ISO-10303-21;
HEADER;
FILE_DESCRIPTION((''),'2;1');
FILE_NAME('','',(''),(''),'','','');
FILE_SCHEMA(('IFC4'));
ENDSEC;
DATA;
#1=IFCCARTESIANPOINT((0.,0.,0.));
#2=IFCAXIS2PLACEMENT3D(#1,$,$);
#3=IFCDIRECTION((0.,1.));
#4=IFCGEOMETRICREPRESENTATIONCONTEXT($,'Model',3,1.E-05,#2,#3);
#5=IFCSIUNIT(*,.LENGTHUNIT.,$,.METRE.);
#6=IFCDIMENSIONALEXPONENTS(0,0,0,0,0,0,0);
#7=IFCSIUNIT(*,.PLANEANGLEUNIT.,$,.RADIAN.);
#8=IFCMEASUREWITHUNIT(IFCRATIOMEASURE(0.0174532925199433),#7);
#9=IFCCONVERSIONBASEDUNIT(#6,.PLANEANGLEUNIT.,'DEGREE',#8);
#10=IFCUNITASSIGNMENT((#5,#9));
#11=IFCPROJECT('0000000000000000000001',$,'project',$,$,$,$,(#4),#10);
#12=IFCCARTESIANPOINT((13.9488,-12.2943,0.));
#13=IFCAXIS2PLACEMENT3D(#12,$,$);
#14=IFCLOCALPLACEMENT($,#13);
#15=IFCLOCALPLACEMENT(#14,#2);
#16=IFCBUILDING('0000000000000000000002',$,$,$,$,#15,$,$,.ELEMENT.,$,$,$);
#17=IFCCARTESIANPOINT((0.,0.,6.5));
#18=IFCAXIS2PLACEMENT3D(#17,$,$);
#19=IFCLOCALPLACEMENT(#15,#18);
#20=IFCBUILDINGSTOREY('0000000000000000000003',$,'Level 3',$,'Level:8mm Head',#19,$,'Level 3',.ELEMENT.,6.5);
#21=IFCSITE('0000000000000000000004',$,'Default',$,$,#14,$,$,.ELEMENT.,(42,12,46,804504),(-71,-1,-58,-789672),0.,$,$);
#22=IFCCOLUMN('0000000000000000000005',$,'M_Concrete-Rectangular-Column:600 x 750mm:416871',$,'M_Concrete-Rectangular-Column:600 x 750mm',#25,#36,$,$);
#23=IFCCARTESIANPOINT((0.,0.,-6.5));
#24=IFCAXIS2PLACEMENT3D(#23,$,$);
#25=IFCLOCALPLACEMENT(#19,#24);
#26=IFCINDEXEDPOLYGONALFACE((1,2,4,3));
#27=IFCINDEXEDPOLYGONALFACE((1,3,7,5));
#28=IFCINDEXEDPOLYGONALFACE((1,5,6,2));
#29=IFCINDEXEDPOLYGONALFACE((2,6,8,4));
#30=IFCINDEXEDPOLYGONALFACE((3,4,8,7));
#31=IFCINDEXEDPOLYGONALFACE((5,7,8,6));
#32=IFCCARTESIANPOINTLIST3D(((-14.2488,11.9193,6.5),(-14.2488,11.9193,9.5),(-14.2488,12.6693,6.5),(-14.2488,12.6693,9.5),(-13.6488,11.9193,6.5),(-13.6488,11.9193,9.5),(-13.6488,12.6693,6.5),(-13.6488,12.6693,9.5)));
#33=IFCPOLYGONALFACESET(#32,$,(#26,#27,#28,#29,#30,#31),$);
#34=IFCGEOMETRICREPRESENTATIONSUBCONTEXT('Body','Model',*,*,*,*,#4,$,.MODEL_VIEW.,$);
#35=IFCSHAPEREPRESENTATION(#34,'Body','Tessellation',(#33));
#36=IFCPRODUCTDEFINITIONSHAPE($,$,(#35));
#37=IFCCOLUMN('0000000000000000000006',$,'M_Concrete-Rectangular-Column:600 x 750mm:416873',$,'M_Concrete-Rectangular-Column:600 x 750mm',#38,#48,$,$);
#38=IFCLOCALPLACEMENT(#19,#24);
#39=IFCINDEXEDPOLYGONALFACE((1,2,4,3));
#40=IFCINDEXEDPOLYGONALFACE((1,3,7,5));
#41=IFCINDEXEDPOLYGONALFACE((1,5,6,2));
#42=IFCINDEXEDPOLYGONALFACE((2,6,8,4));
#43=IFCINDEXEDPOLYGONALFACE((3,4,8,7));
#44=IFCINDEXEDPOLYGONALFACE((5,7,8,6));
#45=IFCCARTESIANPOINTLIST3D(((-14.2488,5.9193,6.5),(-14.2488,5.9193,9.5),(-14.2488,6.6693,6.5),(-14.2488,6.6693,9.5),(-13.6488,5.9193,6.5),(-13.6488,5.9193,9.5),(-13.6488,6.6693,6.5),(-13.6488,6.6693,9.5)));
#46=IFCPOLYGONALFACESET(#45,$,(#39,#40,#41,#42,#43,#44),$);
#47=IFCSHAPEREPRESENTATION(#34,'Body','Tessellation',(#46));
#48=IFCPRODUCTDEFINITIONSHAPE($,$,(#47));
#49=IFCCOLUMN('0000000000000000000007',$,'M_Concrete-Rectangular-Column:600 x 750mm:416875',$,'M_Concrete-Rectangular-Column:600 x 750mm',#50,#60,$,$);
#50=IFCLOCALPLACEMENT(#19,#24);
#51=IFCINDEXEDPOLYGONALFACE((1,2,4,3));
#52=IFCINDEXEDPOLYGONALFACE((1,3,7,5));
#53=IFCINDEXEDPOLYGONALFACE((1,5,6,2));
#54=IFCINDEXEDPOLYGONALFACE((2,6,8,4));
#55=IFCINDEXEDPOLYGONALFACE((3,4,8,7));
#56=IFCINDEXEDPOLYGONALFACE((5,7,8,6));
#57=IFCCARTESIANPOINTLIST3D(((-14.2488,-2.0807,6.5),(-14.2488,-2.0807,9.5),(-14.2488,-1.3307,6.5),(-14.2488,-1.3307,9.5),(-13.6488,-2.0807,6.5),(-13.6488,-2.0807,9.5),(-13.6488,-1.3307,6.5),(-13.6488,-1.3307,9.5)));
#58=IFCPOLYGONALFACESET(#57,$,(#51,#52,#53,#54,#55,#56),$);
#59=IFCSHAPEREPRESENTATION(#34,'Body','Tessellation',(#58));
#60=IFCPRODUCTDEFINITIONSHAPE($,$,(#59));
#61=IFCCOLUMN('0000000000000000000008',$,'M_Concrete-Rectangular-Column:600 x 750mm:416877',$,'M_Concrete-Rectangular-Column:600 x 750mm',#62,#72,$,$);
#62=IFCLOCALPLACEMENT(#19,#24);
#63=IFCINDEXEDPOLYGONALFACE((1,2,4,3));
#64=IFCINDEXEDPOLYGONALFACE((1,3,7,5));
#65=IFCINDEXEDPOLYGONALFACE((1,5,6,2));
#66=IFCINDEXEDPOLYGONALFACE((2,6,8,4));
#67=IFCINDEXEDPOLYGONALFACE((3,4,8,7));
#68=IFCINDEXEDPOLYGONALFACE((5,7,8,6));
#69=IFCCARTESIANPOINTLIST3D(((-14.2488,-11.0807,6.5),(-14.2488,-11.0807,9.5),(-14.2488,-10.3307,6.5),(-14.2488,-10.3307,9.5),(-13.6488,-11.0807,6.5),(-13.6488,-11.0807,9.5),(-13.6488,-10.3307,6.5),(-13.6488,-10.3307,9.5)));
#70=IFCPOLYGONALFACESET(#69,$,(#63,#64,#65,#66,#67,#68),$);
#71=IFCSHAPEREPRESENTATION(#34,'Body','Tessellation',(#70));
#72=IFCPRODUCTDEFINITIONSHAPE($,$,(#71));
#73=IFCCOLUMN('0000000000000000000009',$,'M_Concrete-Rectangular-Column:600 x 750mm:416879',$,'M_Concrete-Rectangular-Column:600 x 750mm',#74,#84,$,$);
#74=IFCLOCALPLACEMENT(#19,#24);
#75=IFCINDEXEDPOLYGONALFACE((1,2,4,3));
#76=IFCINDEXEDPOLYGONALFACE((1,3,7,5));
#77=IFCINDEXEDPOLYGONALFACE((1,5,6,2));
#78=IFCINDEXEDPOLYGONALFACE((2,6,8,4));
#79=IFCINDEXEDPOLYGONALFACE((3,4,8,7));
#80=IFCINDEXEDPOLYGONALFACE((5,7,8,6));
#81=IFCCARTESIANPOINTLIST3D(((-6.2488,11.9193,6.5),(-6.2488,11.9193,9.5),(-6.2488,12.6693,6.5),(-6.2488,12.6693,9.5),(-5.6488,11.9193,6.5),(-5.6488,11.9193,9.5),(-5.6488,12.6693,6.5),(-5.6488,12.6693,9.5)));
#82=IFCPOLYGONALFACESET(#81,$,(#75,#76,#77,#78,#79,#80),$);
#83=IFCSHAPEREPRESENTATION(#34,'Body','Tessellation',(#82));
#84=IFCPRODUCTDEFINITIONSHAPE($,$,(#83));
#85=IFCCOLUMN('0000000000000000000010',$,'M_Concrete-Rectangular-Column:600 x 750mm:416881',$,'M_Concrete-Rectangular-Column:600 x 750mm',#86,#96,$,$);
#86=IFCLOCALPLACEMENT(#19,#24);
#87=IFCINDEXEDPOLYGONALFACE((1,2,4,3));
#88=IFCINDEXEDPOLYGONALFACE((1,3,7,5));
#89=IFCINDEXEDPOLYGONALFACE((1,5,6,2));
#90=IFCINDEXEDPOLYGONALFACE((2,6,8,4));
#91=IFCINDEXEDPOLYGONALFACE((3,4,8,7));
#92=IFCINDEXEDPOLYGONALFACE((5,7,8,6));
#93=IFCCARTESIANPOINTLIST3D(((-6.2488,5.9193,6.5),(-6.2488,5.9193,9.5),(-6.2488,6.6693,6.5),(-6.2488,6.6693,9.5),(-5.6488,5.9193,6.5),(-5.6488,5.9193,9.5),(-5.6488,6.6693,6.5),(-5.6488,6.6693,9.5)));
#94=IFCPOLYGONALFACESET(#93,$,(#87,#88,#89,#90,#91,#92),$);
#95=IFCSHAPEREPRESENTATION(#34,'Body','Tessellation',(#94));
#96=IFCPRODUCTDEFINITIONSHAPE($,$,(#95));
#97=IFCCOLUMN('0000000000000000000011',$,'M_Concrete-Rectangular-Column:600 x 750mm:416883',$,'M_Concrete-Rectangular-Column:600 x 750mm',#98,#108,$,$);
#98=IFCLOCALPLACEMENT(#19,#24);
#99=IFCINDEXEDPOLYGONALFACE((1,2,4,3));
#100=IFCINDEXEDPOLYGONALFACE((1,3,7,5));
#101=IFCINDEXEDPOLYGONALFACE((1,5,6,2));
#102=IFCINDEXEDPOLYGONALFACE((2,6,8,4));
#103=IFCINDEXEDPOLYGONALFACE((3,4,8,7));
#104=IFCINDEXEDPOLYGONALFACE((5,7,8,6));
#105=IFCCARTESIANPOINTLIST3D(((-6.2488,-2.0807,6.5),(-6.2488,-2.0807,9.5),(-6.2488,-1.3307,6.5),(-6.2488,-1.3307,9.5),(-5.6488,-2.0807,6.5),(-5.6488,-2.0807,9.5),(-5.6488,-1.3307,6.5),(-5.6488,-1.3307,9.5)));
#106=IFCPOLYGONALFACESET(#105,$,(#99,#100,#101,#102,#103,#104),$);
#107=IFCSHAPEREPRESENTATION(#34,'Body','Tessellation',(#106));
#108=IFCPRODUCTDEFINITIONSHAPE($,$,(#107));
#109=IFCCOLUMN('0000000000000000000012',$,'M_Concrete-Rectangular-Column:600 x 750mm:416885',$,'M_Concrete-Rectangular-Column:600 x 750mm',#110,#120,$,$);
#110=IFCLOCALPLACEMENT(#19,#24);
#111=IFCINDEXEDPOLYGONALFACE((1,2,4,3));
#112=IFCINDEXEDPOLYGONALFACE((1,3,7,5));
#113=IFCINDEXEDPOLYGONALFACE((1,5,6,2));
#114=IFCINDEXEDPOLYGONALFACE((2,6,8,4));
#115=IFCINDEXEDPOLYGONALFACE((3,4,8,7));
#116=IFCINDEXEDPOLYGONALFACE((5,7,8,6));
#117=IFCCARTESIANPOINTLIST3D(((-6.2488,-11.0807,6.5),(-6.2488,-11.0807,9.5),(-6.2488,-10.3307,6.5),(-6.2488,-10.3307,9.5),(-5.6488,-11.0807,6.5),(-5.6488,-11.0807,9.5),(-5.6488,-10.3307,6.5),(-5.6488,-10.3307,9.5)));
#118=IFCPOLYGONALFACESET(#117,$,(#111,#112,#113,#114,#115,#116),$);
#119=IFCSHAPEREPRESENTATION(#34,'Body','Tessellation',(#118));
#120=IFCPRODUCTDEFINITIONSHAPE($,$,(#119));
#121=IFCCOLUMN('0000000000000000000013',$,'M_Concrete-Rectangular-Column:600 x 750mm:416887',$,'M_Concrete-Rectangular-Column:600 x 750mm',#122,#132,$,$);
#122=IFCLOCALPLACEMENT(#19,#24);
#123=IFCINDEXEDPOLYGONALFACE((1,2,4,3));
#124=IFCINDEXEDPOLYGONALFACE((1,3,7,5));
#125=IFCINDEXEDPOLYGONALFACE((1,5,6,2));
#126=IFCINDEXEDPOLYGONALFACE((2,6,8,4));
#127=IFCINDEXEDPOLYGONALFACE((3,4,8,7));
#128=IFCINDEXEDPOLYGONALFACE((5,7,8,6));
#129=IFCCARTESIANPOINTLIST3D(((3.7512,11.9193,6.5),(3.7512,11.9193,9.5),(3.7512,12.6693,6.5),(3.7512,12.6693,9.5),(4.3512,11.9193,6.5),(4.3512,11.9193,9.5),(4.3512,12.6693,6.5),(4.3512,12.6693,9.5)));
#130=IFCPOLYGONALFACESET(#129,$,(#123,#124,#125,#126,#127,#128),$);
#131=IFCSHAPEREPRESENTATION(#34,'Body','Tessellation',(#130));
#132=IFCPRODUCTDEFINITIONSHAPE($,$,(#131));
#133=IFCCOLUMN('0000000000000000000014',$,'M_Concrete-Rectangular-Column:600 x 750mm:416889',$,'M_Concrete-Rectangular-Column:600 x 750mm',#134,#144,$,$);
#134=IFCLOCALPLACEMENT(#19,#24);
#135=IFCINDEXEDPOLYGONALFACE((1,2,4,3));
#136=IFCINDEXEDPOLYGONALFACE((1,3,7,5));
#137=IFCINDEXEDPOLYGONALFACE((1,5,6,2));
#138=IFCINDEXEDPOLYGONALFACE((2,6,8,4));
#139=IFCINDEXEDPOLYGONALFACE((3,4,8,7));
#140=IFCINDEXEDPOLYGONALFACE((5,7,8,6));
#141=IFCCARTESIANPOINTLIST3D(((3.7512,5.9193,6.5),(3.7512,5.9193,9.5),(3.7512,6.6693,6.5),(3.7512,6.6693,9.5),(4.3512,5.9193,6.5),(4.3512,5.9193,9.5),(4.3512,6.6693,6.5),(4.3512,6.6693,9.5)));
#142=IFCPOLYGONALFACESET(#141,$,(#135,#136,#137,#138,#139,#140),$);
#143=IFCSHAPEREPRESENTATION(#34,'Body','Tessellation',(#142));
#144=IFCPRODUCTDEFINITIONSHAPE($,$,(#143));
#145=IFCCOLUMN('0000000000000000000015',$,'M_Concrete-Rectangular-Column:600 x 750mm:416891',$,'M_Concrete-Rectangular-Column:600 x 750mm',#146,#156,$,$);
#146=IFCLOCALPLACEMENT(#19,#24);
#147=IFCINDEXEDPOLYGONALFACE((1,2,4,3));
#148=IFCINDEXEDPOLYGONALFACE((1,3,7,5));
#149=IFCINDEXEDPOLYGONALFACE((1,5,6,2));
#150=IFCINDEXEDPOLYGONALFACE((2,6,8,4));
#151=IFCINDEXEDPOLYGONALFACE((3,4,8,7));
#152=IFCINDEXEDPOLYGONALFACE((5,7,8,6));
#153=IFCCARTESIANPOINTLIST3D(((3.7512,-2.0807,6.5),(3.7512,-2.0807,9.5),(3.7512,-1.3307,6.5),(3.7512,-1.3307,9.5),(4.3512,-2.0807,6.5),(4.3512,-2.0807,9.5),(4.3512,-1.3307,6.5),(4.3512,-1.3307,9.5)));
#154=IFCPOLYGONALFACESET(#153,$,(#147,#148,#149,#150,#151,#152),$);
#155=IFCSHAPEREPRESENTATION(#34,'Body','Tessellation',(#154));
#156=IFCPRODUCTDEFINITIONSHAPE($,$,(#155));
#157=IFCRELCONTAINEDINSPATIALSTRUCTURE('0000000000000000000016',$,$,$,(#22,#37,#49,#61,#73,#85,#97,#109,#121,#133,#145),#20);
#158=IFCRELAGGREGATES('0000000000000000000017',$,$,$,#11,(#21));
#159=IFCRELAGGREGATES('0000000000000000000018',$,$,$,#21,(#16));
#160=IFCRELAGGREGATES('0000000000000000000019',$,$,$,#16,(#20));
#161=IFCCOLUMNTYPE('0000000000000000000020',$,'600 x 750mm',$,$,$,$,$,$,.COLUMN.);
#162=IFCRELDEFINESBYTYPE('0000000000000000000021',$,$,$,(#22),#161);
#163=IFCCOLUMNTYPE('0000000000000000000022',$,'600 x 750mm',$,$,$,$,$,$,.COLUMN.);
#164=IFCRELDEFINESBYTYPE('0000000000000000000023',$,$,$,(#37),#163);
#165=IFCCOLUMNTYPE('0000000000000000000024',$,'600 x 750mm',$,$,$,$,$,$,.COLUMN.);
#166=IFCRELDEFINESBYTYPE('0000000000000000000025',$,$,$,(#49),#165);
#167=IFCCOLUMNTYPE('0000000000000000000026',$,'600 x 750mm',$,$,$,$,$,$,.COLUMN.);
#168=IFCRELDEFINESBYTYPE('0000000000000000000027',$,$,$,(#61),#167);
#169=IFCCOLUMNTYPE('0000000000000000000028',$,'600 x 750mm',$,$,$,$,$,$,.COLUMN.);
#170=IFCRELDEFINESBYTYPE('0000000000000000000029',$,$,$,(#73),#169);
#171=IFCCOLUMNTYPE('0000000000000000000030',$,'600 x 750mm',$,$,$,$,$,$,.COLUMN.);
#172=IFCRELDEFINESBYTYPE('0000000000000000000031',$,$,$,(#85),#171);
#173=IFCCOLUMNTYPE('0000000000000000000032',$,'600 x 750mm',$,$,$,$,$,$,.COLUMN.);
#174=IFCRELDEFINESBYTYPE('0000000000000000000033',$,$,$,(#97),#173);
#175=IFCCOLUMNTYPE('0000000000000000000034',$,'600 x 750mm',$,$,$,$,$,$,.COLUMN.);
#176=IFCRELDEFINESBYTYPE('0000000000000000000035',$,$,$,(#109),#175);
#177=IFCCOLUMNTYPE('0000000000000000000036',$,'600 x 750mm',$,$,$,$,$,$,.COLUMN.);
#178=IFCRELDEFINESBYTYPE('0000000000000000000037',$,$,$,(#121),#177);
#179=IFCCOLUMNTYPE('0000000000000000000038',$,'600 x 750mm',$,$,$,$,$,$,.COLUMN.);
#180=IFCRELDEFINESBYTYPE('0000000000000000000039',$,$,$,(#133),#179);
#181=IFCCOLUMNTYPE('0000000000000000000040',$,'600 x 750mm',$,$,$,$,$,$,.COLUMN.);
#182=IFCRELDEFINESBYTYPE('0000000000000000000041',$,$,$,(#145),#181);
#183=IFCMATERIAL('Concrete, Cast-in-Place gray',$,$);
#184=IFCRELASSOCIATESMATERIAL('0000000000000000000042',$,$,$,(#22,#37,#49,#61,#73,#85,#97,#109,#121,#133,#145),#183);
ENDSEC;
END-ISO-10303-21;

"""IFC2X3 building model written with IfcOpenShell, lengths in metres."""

from ifc_helpers import new_model, entity, si_unit, converted_unit, direction, frame, frame_2d, origin, origin_2d_with_axis, place, context, subcontext, project, spatial, rectangle, extrude, source, transform, mapped, material, type_object, type_shapes, element, save


model = new_model("IFC2X3")

# Units and contexts
model_context = context("Model", 3, precision=1e-05, world=origin(), true_north=direction((0.0, 1.0)))
body_context = subcontext(model_context, "Body", "Model", "MODEL_VIEW")
ifc_project = project(units=[si_unit("LENGTHUNIT", "METRE"), converted_unit("PLANEANGLEUNIT", "DEGREE", entity("IfcRatioMeasure", 0.0174532925199433), si_unit("PLANEANGLEUNIT", "RADIAN"), dimensions=[0, 0, 0, 0, 0, 0, 0])], contexts=[model_context])

# Site, building, storey
site_placement = place(None, frame((13.9488, -12.2943, 0.0)))
site = spatial("IfcSite", under=ifc_project, at=site_placement, Name="Default", CompositionType="ELEMENT", RefLatitude=(42, 12, 46, 804504), RefLongitude=(-71, -1, -58, -789672), RefElevation=0.0)
building_placement = place(site_placement, origin())
building = spatial("IfcBuilding", under=site, at=building_placement, CompositionType="ELEMENT")
storey_placement = place(building_placement, frame((0.0, 0.0, 6.5)))
storey = spatial("IfcBuildingStorey", under=building, at=storey_placement, Name="Level 3", ObjectType="Level:8mm Head", LongName="Level 3", CompositionType="ELEMENT", Elevation=6.5)

# Columns
ifc_material = material(Name="Concrete, Cast-in-Place gray")
column_type_1 = type_object("IfcColumnType", Name="600 x 750mm", PredefinedType="COLUMN")
shared_shape_1 = source(origin(), body_context, "Body", "SweptSolid", [
    extrude(rectangle(XDim=0.75, YDim=0.6, at=frame_2d((0.0, 0.0), x_axis=(1.0, 0.0))), frame((-13.9488, 12.2943, 6.5), z_axis=(0.0, 0.0, 1.0), x_axis=(0.0, -1.0, 0.0)), (0.0, 0.0, 1.0), 3.0),
])
type_shapes(column_type_1, [shared_shape_1])
column_1_placement = place(storey_placement, frame((0.0, 0.0, -6.5)))
element("IfcColumn", 1, at=column_1_placement, inside=storey, type_object=column_type_1, material=ifc_material, Name="M_Concrete-Rectangular-Column:600 x 750mm:416871", ObjectType="M_Concrete-Rectangular-Column:600 x 750mm", context=body_context, shape_type="MappedRepresentation", body=[
    mapped(shared_shape_1, transform((0.0, 0.0, 0.0), scale=1.0)),
])
column_type_2 = type_object("IfcColumnType", Name="600 x 750mm", PredefinedType="COLUMN")
shared_shape_2 = source(origin(), body_context, "Body", "SweptSolid", [
    extrude(rectangle(XDim=0.75, YDim=0.6, at=frame_2d((0.0, 0.0), x_axis=(1.0, 0.0))), frame((-13.9488, 6.2943, 6.5), z_axis=(0.0, 0.0, 1.0), x_axis=(0.0, -1.0, 0.0)), (0.0, 0.0, 1.0), 3.0),
])
type_shapes(column_type_2, [shared_shape_2])
column_2_placement = place(storey_placement, frame((0.0, 0.0, -6.5)))
element("IfcColumn", 2, at=column_2_placement, inside=storey, type_object=column_type_2, material=ifc_material, Name="M_Concrete-Rectangular-Column:600 x 750mm:416873", ObjectType="M_Concrete-Rectangular-Column:600 x 750mm", context=body_context, shape_type="MappedRepresentation", body=[
    mapped(shared_shape_2, transform((0.0, 0.0, 0.0), scale=1.0)),
])
column_type_3 = type_object("IfcColumnType", Name="600 x 750mm", PredefinedType="COLUMN")
shared_shape_3 = source(origin(), body_context, "Body", "SweptSolid", [
    extrude(rectangle(XDim=0.75, YDim=0.6, at=frame_2d((0.0, 0.0), x_axis=(1.0, 0.0))), frame((-13.9488, -1.7057, 6.5), z_axis=(0.0, 0.0, 1.0), x_axis=(0.0, -1.0, 0.0)), (0.0, 0.0, 1.0), 3.0),
])
type_shapes(column_type_3, [shared_shape_3])
column_3_placement = place(storey_placement, frame((0.0, 0.0, -6.5)))
element("IfcColumn", 3, at=column_3_placement, inside=storey, type_object=column_type_3, material=ifc_material, Name="M_Concrete-Rectangular-Column:600 x 750mm:416875", ObjectType="M_Concrete-Rectangular-Column:600 x 750mm", context=body_context, shape_type="MappedRepresentation", body=[
    mapped(shared_shape_3, transform((0.0, 0.0, 0.0), scale=1.0)),
])
column_type_4 = type_object("IfcColumnType", Name="600 x 750mm", PredefinedType="COLUMN")
shared_shape_4 = source(origin(), body_context, "Body", "SweptSolid", [
    extrude(rectangle(XDim=0.75, YDim=0.6, at=frame_2d((0.0, 0.0), x_axis=(1.0, 0.0))), frame((-13.9488, -10.7057, 6.5), z_axis=(0.0, 0.0, 1.0), x_axis=(0.0, -1.0, 0.0)), (0.0, 0.0, 1.0), 3.0),
])
type_shapes(column_type_4, [shared_shape_4])
column_4_placement = place(storey_placement, frame((0.0, 0.0, -6.5)))
element("IfcColumn", 4, at=column_4_placement, inside=storey, type_object=column_type_4, material=ifc_material, Name="M_Concrete-Rectangular-Column:600 x 750mm:416877", ObjectType="M_Concrete-Rectangular-Column:600 x 750mm", context=body_context, shape_type="MappedRepresentation", body=[
    mapped(shared_shape_4, transform((0.0, 0.0, 0.0), scale=1.0)),
])
column_type_5 = type_object("IfcColumnType", Name="600 x 750mm", PredefinedType="COLUMN")
shared_shape_5 = source(origin(), body_context, "Body", "SweptSolid", [
    extrude(rectangle(XDim=0.75, YDim=0.6, at=origin_2d_with_axis()), frame((-5.9488, 12.2943, 6.5), z_axis=(0.0, 0.0, 1.0), x_axis=(0.0, -1.0, 0.0)), (0.0, 0.0, 1.0), 3.0),
])
type_shapes(column_type_5, [shared_shape_5])
column_5_placement = place(storey_placement, frame((0.0, 0.0, -6.5)))
element("IfcColumn", 5, at=column_5_placement, inside=storey, type_object=column_type_5, material=ifc_material, Name="M_Concrete-Rectangular-Column:600 x 750mm:416879", ObjectType="M_Concrete-Rectangular-Column:600 x 750mm", context=body_context, shape_type="MappedRepresentation", body=[
    mapped(shared_shape_5, transform((0.0, 0.0, 0.0), scale=1.0)),
])
column_type_6 = type_object("IfcColumnType", Name="600 x 750mm", PredefinedType="COLUMN")
shared_shape_6 = source(origin(), body_context, "Body", "SweptSolid", [
    extrude(rectangle(XDim=0.75, YDim=0.6, at=origin_2d_with_axis()), frame((-5.9488, 6.2943, 6.5), z_axis=(0.0, 0.0, 1.0), x_axis=(0.0, -1.0, 0.0)), (0.0, 0.0, 1.0), 3.0),
])
type_shapes(column_type_6, [shared_shape_6])
column_6_placement = place(storey_placement, frame((0.0, 0.0, -6.5)))
element("IfcColumn", 6, at=column_6_placement, inside=storey, type_object=column_type_6, material=ifc_material, Name="M_Concrete-Rectangular-Column:600 x 750mm:416881", ObjectType="M_Concrete-Rectangular-Column:600 x 750mm", context=body_context, shape_type="MappedRepresentation", body=[
    mapped(shared_shape_6, transform((0.0, 0.0, 0.0), scale=1.0)),
])
column_type_7 = type_object("IfcColumnType", Name="600 x 750mm", PredefinedType="COLUMN")
shared_shape_7 = source(origin(), body_context, "Body", "SweptSolid", [
    extrude(rectangle(XDim=0.75, YDim=0.6, at=frame_2d((0.0, 0.0), x_axis=(1.0, 0.0))), frame((-5.9488, -1.7057, 6.5), z_axis=(0.0, 0.0, 1.0), x_axis=(0.0, -1.0, 0.0)), (0.0, 0.0, 1.0), 3.0),
])
type_shapes(column_type_7, [shared_shape_7])
column_7_placement = place(storey_placement, frame((0.0, 0.0, -6.5)))
element("IfcColumn", 7, at=column_7_placement, inside=storey, type_object=column_type_7, material=ifc_material, Name="M_Concrete-Rectangular-Column:600 x 750mm:416883", ObjectType="M_Concrete-Rectangular-Column:600 x 750mm", context=body_context, shape_type="MappedRepresentation", body=[
    mapped(shared_shape_7, transform((0.0, 0.0, 0.0), scale=1.0)),
])
column_type_8 = type_object("IfcColumnType", Name="600 x 750mm", PredefinedType="COLUMN")
shared_shape_8 = source(origin(), body_context, "Body", "SweptSolid", [
    extrude(rectangle(XDim=0.75, YDim=0.6, at=origin_2d_with_axis()), frame((-5.9488, -10.7057, 6.5), z_axis=(0.0, 0.0, 1.0), x_axis=(0.0, -1.0, 0.0)), (0.0, 0.0, 1.0), 3.0),
])
type_shapes(column_type_8, [shared_shape_8])
column_8_placement = place(storey_placement, frame((0.0, 0.0, -6.5)))
element("IfcColumn", 8, at=column_8_placement, inside=storey, type_object=column_type_8, material=ifc_material, Name="M_Concrete-Rectangular-Column:600 x 750mm:416885", ObjectType="M_Concrete-Rectangular-Column:600 x 750mm", context=body_context, shape_type="MappedRepresentation", body=[
    mapped(shared_shape_8, transform((0.0, 0.0, 0.0), scale=1.0)),
])
column_type_9 = type_object("IfcColumnType", Name="600 x 750mm", PredefinedType="COLUMN")
shared_shape_9 = source(origin(), body_context, "Body", "SweptSolid", [
    extrude(rectangle(XDim=0.75, YDim=0.6, at=origin_2d_with_axis()), frame((4.0512, 12.2943, 6.5), z_axis=(0.0, 0.0, 1.0), x_axis=(0.0, -1.0, 0.0)), (0.0, 0.0, 1.0), 3.0),
])
type_shapes(column_type_9, [shared_shape_9])
column_9_placement = place(storey_placement, frame((0.0, 0.0, -6.5)))
element("IfcColumn", 9, at=column_9_placement, inside=storey, type_object=column_type_9, material=ifc_material, Name="M_Concrete-Rectangular-Column:600 x 750mm:416887", ObjectType="M_Concrete-Rectangular-Column:600 x 750mm", context=body_context, shape_type="MappedRepresentation", body=[
    mapped(shared_shape_9, transform((0.0, 0.0, 0.0), scale=1.0)),
])
column_type_10 = type_object("IfcColumnType", Name="600 x 750mm", PredefinedType="COLUMN")
shared_shape_10 = source(origin(), body_context, "Body", "SweptSolid", [
    extrude(rectangle(XDim=0.75, YDim=0.6, at=origin_2d_with_axis()), frame((4.0512, 6.2943, 6.5), z_axis=(0.0, 0.0, 1.0), x_axis=(0.0, -1.0, 0.0)), (0.0, 0.0, 1.0), 3.0),
])
type_shapes(column_type_10, [shared_shape_10])
column_10_placement = place(storey_placement, frame((0.0, 0.0, -6.5)))
element("IfcColumn", 10, at=column_10_placement, inside=storey, type_object=column_type_10, material=ifc_material, Name="M_Concrete-Rectangular-Column:600 x 750mm:416889", ObjectType="M_Concrete-Rectangular-Column:600 x 750mm", context=body_context, shape_type="MappedRepresentation", body=[
    mapped(shared_shape_10, transform((0.0, 0.0, 0.0), scale=1.0)),
])
column_type_11 = type_object("IfcColumnType", Name="600 x 750mm", PredefinedType="COLUMN")
shared_shape_11 = source(origin(), body_context, "Body", "SweptSolid", [
    extrude(rectangle(XDim=0.75, YDim=0.6, at=frame_2d((0.0, 0.0), x_axis=(1.0, 0.0))), frame((4.0512, -1.7057, 6.5), z_axis=(0.0, 0.0, 1.0), x_axis=(0.0, -1.0, 0.0)), (0.0, 0.0, 1.0), 3.0),
])
type_shapes(column_type_11, [shared_shape_11])
column_11_placement = place(storey_placement, frame((0.0, 0.0, -6.5)))
element("IfcColumn", 11, at=column_11_placement, inside=storey, type_object=column_type_11, material=ifc_material, Name="M_Concrete-Rectangular-Column:600 x 750mm:416891", ObjectType="M_Concrete-Rectangular-Column:600 x 750mm", context=body_context, shape_type="MappedRepresentation", body=[
    mapped(shared_shape_11, transform((0.0, 0.0, 0.0), scale=1.0)),
])

save(model, "model.ifc")
